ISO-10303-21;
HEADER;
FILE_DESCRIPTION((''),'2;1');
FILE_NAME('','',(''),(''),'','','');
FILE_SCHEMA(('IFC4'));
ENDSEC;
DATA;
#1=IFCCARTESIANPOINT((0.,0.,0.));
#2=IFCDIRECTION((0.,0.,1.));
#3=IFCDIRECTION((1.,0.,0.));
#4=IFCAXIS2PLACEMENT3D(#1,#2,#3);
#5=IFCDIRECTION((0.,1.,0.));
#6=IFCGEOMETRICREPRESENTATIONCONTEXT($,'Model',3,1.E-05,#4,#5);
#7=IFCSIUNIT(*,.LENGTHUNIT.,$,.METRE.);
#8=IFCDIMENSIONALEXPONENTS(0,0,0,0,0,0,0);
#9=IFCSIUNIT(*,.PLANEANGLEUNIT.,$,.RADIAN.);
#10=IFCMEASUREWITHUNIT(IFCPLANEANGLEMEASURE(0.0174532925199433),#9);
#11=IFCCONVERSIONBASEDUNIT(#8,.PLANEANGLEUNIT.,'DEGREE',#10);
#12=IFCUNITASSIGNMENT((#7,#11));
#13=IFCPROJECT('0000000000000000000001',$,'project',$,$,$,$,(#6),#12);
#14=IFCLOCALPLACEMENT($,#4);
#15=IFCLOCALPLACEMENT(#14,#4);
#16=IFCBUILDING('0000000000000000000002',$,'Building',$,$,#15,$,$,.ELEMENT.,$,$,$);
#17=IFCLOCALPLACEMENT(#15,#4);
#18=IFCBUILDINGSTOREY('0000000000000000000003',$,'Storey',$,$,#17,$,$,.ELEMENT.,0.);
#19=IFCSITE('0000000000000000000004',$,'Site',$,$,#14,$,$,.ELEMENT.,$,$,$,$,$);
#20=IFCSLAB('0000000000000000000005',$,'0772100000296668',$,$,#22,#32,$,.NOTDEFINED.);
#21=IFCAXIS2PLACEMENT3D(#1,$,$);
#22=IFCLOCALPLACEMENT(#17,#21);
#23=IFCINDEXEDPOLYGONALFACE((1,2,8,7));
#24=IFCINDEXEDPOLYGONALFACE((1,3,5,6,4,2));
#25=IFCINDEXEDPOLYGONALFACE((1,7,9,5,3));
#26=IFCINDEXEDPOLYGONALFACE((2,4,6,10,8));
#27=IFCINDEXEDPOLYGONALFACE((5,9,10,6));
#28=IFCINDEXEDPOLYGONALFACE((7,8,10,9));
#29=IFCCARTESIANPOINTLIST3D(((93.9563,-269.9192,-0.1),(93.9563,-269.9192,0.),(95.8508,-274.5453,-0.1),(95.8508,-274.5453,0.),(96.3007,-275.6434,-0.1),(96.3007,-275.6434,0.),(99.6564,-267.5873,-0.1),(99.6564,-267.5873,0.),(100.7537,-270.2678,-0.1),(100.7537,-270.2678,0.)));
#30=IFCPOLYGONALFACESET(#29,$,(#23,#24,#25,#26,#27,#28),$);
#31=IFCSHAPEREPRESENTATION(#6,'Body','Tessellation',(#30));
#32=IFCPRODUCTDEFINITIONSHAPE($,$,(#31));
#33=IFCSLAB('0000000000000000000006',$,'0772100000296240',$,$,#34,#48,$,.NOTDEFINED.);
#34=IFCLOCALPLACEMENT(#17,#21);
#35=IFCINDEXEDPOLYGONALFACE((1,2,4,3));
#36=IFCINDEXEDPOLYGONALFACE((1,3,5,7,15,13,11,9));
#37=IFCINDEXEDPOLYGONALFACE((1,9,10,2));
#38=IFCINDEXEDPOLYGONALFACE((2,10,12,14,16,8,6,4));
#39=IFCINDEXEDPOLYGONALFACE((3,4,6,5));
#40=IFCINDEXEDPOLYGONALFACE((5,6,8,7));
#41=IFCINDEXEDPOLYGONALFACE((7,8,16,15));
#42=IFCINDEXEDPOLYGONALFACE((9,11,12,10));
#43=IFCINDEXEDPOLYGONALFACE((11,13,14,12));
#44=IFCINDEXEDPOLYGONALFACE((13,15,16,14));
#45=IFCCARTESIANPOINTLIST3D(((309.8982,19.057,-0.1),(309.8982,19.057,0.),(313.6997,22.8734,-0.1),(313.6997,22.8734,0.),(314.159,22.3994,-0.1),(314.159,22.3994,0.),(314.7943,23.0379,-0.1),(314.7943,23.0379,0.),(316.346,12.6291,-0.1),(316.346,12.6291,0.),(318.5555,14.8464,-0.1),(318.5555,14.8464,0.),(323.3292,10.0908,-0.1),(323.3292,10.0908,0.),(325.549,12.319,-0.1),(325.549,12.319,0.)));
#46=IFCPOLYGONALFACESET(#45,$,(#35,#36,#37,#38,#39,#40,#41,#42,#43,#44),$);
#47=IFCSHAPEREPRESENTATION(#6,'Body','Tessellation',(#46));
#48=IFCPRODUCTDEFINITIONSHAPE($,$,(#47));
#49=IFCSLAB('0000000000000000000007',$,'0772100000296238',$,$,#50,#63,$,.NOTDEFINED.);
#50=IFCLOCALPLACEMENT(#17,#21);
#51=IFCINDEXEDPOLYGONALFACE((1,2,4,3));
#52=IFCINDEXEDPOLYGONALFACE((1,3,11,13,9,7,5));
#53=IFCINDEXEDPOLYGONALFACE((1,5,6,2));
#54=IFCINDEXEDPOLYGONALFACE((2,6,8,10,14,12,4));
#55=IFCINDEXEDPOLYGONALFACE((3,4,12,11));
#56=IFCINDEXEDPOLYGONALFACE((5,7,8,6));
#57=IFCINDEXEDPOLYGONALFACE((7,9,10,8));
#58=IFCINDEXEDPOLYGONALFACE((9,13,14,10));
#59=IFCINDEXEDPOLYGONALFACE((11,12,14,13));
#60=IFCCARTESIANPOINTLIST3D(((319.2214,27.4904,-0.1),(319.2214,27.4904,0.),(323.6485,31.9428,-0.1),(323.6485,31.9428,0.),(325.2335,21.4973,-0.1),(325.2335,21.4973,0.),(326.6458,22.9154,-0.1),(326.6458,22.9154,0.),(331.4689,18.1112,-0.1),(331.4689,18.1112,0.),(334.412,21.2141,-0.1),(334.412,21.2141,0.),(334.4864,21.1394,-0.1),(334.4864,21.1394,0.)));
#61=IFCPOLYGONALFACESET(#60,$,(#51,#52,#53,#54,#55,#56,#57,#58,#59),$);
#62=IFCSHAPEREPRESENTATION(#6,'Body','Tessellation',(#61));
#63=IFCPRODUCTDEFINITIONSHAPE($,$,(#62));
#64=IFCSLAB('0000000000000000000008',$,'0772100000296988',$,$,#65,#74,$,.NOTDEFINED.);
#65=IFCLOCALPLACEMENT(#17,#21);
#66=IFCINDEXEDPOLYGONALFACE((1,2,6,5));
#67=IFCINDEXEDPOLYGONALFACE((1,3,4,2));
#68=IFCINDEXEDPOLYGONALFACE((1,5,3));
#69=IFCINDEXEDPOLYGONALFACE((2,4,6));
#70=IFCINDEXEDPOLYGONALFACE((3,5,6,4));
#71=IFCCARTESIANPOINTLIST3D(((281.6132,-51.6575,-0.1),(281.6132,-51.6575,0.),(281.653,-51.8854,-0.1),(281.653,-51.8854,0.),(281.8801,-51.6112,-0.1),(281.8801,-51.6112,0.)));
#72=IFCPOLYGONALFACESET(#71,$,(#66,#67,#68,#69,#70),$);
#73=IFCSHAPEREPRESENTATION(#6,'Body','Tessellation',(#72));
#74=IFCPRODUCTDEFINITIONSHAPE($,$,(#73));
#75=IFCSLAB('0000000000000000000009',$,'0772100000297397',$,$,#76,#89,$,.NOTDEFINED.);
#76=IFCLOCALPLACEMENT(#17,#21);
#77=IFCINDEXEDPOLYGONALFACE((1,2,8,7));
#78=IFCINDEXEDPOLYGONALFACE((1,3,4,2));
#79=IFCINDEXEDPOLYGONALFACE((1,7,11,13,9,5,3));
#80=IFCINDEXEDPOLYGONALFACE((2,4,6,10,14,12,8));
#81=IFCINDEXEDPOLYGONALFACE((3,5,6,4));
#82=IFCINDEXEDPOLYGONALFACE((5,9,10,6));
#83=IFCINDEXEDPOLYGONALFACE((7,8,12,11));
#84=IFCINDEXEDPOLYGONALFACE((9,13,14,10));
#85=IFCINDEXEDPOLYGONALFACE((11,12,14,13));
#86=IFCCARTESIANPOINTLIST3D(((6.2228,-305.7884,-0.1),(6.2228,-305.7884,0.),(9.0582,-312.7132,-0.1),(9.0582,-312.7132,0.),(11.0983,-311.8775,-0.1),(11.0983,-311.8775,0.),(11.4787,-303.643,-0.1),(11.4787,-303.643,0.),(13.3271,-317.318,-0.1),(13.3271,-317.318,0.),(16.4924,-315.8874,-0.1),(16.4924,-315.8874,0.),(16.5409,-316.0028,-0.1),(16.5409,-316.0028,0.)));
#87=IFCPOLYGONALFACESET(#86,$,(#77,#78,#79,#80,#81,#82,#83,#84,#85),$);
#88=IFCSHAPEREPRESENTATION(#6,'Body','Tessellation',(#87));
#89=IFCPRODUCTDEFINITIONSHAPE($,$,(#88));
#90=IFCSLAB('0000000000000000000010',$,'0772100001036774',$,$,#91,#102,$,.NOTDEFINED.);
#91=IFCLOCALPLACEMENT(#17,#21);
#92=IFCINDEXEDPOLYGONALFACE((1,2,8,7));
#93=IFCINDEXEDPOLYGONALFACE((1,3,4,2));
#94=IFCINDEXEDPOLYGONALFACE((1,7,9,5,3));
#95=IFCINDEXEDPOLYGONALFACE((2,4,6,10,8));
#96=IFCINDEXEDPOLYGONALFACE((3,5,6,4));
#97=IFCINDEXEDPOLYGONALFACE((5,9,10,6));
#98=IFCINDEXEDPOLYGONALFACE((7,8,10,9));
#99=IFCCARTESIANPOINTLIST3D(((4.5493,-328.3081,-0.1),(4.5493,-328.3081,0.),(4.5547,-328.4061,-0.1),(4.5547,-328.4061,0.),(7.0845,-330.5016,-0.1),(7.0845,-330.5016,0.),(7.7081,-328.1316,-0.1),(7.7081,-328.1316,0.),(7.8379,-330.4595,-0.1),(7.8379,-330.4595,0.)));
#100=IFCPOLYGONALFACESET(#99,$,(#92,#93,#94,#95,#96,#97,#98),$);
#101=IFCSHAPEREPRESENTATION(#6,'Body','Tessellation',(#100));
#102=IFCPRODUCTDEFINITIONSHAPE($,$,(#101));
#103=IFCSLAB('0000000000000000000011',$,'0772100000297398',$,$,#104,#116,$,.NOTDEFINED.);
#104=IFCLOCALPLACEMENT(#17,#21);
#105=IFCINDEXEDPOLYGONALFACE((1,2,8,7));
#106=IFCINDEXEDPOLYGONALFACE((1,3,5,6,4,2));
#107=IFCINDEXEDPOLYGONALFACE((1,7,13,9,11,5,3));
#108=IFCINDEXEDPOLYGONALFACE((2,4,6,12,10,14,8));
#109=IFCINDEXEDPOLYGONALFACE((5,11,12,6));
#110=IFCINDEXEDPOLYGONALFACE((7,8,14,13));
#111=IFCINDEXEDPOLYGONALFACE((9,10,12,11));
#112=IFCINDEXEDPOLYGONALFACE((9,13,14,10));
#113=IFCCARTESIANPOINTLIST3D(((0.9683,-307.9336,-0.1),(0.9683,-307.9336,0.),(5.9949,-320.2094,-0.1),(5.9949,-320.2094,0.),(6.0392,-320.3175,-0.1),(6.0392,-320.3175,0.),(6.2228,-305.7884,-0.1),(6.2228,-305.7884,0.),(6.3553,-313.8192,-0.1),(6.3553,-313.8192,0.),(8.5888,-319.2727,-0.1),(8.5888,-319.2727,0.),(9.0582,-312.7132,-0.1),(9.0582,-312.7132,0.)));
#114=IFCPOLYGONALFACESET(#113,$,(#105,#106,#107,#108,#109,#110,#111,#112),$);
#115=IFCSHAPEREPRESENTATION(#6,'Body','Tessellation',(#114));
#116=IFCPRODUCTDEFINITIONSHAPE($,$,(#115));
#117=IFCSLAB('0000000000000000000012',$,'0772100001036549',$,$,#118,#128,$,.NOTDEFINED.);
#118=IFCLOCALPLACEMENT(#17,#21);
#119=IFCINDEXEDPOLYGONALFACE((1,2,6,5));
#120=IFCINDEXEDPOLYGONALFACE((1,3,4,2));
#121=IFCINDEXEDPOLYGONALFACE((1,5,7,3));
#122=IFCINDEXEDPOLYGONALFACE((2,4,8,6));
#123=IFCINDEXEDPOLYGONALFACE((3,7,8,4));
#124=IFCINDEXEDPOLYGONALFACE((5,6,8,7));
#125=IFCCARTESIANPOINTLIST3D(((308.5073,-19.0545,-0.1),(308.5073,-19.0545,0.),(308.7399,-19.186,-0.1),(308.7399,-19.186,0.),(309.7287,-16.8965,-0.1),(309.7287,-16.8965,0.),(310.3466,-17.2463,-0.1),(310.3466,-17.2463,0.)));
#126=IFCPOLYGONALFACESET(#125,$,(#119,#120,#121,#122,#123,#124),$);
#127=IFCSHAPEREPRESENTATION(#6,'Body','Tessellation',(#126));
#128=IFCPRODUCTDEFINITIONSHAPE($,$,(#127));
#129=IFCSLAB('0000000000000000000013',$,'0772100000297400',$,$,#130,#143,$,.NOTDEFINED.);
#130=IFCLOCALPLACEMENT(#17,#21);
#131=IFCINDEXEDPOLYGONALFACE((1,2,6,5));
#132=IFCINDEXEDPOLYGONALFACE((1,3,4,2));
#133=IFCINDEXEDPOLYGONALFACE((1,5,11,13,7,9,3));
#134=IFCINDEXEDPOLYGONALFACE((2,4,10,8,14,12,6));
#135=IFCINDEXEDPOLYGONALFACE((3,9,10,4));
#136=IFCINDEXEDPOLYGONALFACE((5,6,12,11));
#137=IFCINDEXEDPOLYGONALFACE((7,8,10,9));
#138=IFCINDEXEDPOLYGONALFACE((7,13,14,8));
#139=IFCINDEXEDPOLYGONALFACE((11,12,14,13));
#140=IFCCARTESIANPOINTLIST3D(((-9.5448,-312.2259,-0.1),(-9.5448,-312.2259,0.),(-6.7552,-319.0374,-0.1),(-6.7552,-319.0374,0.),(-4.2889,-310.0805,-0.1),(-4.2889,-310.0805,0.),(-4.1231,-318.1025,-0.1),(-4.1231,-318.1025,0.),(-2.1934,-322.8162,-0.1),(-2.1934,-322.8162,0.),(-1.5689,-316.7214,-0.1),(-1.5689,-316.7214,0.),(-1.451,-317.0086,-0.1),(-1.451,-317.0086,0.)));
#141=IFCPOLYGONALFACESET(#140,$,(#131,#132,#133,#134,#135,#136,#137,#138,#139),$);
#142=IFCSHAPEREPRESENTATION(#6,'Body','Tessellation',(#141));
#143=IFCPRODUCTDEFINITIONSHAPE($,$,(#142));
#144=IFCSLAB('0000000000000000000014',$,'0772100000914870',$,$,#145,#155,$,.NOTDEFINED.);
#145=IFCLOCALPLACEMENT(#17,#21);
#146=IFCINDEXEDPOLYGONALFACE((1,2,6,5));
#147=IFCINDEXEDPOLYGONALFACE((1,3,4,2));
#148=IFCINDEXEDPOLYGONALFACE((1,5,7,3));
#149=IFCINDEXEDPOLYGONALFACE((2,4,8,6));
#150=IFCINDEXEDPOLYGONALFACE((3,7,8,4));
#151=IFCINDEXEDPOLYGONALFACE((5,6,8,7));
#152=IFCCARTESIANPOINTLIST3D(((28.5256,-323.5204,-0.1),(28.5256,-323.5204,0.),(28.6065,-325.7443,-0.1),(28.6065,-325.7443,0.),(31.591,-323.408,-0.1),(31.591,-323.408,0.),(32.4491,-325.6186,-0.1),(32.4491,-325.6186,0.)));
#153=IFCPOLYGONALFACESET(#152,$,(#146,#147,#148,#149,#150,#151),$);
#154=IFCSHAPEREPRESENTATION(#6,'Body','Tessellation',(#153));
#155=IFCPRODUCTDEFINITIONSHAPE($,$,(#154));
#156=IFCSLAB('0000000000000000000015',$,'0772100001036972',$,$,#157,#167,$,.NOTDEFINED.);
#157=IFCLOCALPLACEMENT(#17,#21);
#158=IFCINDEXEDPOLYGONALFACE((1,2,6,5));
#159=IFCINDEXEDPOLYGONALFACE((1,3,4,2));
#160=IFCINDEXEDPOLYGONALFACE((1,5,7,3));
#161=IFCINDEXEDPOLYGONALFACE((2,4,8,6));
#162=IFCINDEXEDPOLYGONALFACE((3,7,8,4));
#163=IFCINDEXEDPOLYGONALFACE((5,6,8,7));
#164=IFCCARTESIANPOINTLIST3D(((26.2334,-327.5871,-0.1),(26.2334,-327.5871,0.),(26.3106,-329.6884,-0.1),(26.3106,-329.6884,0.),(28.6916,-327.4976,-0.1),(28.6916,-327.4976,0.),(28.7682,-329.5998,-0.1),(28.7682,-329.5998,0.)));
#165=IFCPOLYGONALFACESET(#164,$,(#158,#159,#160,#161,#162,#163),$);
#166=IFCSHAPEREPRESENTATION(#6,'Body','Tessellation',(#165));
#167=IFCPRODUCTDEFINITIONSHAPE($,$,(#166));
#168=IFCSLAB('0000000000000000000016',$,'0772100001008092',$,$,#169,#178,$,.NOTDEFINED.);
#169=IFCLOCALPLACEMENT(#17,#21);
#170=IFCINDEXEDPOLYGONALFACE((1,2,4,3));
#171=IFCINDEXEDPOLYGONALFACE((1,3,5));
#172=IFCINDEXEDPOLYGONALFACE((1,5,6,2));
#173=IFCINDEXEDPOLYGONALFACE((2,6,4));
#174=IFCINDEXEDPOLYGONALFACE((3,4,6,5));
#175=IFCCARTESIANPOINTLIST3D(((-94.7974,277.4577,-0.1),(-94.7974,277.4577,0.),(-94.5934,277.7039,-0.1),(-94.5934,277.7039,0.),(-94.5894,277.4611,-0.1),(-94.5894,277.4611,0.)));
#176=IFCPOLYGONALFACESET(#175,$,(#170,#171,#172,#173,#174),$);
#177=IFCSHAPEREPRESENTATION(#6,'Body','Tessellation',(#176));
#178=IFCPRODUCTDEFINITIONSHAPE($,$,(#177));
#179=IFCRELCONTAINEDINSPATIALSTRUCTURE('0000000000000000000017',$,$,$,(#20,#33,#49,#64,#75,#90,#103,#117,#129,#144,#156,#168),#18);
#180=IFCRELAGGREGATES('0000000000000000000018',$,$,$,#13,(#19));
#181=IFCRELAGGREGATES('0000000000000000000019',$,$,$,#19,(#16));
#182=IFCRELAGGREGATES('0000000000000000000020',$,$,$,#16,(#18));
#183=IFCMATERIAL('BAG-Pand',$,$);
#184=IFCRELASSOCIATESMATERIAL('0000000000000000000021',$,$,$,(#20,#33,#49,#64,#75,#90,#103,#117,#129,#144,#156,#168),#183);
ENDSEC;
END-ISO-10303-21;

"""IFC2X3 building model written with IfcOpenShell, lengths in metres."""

from ifc_helpers import new_model, entity, si_unit, converted_unit, direction, frame, origin_with_axes, place, context, project, spatial, polyline, outline, extrude, material, element, save


model = new_model("IFC2X3")

# Units and contexts
model_context = context("Model", 3, precision=1e-05, world=origin_with_axes(), true_north=direction((0.0, 1.0, 0.0)))
ifc_project = project(units=[si_unit("LENGTHUNIT", "METRE"), converted_unit("PLANEANGLEUNIT", "DEGREE", entity("IfcPlaneAngleMeasure", 0.0174532925199433), si_unit("PLANEANGLEUNIT", "RADIAN"), dimensions=[0, 0, 0, 0, 0, 0, 0])], contexts=[model_context])

# Site, building, storey
site_placement = place(None, origin_with_axes())
site = spatial("IfcSite", under=ifc_project, at=site_placement, Name="Site", CompositionType="ELEMENT")
building_placement = place(site_placement, origin_with_axes())
building = spatial("IfcBuilding", under=site, at=building_placement, Name="Building", CompositionType="ELEMENT")
storey_placement = place(building_placement, origin_with_axes())
storey = spatial("IfcBuildingStorey", under=building, at=storey_placement, Name="Storey", CompositionType="ELEMENT", Elevation=0.0)

# Slabs
ifc_material = material(Name="BAG-Pand")
slab_1_placement = place(storey_placement, frame((0.0, 0.0, -0.1), z_axis=(0.0, 0.0, 1.0), x_axis=(1.0, 0.0, 0.0)))
element("IfcSlab", 1, at=slab_1_placement, inside=storey, material=ifc_material, Name="0772100000296668", PredefinedType="NOTDEFINED", context=model_context, shape_type="SweptSolid", body=[
    extrude(outline(polyline([(95.8508, -274.5453), (93.9563, -269.9192), (99.6564, -267.5873), (100.7537, -270.2678), (96.3007, -275.6434), (95.8508, -274.5453)])), origin_with_axes(), (0.0, 0.0, 1.0), 0.1),
])
slab_2_placement = place(storey_placement, frame((0.0, 0.0, -0.1), z_axis=(0.0, 0.0, 1.0), x_axis=(1.0, 0.0, 0.0)))
element("IfcSlab", 2, at=slab_2_placement, inside=storey, material=ifc_material, Name="0772100000296240", PredefinedType="NOTDEFINED", context=model_context, shape_type="SweptSolid", body=[
    extrude(outline(polyline([(309.8982, 19.057), (313.6997, 22.8734), (314.159, 22.3994), (314.7943, 23.0379), (325.549, 12.319), (323.3292, 10.0908), (318.5555, 14.8464), (316.346, 12.6291), (309.8982, 19.057)])), origin_with_axes(), (0.0, 0.0, 1.0), 0.1),
])
slab_3_placement = place(storey_placement, frame((0.0, 0.0, -0.1), z_axis=(0.0, 0.0, 1.0), x_axis=(1.0, 0.0, 0.0)))
element("IfcSlab", 3, at=slab_3_placement, inside=storey, material=ifc_material, Name="0772100000296238", PredefinedType="NOTDEFINED", context=model_context, shape_type="SweptSolid", body=[
    extrude(outline(polyline([(319.2214, 27.4904), (323.6485, 31.9428), (334.412, 21.2141), (334.4864, 21.1394), (331.4689, 18.1112), (326.6458, 22.9154), (325.2335, 21.4973), (319.2214, 27.4904)])), origin_with_axes(), (0.0, 0.0, 1.0), 0.1),
])
slab_4_placement = place(storey_placement, frame((0.0, 0.0, -0.1), z_axis=(0.0, 0.0, 1.0), x_axis=(1.0, 0.0, 0.0)))
element("IfcSlab", 4, at=slab_4_placement, inside=storey, material=ifc_material, Name="0772100000296988", PredefinedType="NOTDEFINED", context=model_context, shape_type="SweptSolid", body=[
    extrude(outline(polyline([(281.6132, -51.6575), (281.8801, -51.6112), (281.653, -51.8854), (281.6132, -51.6575)])), origin_with_axes(), (0.0, 0.0, 1.0), 0.1),
])
slab_5_placement = place(storey_placement, frame((0.0, 0.0, -0.1), z_axis=(0.0, 0.0, 1.0), x_axis=(1.0, 0.0, 0.0)))
element("IfcSlab", 5, at=slab_5_placement, inside=storey, material=ifc_material, Name="0772100000297397", PredefinedType="NOTDEFINED", context=model_context, shape_type="SweptSolid", body=[
    extrude(outline(polyline([(11.4787, -303.643), (16.4924, -315.8874), (16.5409, -316.0028), (13.3271, -317.318), (11.0983, -311.8775), (9.0582, -312.7132), (6.2228, -305.7884), (11.4787, -303.643)])), origin_with_axes(), (0.0, 0.0, 1.0), 0.1),
])
slab_6_placement = place(storey_placement, frame((0.0, 0.0, -0.1), z_axis=(0.0, 0.0, 1.0), x_axis=(1.0, 0.0, 0.0)))
element("IfcSlab", 6, at=slab_6_placement, inside=storey, material=ifc_material, Name="0772100001036774", PredefinedType="NOTDEFINED", context=model_context, shape_type="SweptSolid", body=[
    extrude(outline(polyline([(4.5493, -328.3081), (7.7081, -328.1316), (7.8379, -330.4595), (7.0845, -330.5016), (4.5547, -328.4061), (4.5493, -328.3081)])), origin_with_axes(), (0.0, 0.0, 1.0), 0.1),
])
slab_7_placement = place(storey_placement, frame((0.0, 0.0, -0.1), z_axis=(0.0, 0.0, 1.0), x_axis=(1.0, 0.0, 0.0)))
element("IfcSlab", 7, at=slab_7_placement, inside=storey, material=ifc_material, Name="0772100000297398", PredefinedType="NOTDEFINED", context=model_context, shape_type="SweptSolid", body=[
    extrude(outline(polyline([(5.9949, -320.2094), (0.9683, -307.9336), (6.2228, -305.7884), (9.0582, -312.7132), (6.3553, -313.8192), (8.5888, -319.2727), (6.0392, -320.3175), (5.9949, -320.2094)])), origin_with_axes(), (0.0, 0.0, 1.0), 0.1),
])
slab_8_placement = place(storey_placement, frame((0.0, 0.0, -0.1), z_axis=(0.0, 0.0, 1.0), x_axis=(1.0, 0.0, 0.0)))
element("IfcSlab", 8, at=slab_8_placement, inside=storey, material=ifc_material, Name="0772100001036549", PredefinedType="NOTDEFINED", context=model_context, shape_type="SweptSolid", body=[
    extrude(outline(polyline([(308.5073, -19.0545), (309.7287, -16.8965), (310.3466, -17.2463), (308.7399, -19.186), (308.5073, -19.0545)])), origin_with_axes(), (0.0, 0.0, 1.0), 0.1),
])
slab_9_placement = place(storey_placement, frame((0.0, 0.0, -0.1), z_axis=(0.0, 0.0, 1.0), x_axis=(1.0, 0.0, 0.0)))
element("IfcSlab", 9, at=slab_9_placement, inside=storey, material=ifc_material, Name="0772100000297400", PredefinedType="NOTDEFINED", context=model_context, shape_type="SweptSolid", body=[
    extrude(outline(polyline([(-9.5448, -312.2259), (-4.2889, -310.0805), (-1.5689, -316.7214), (-1.451, -317.0086), (-4.1231, -318.1025), (-2.1934, -322.8162), (-6.7552, -319.0374), (-9.5448, -312.2259)])), origin_with_axes(), (0.0, 0.0, 1.0), 0.1),
])
slab_10_placement = place(storey_placement, frame((0.0, 0.0, -0.1), z_axis=(0.0, 0.0, 1.0), x_axis=(1.0, 0.0, 0.0)))
element("IfcSlab", 10, at=slab_10_placement, inside=storey, material=ifc_material, Name="0772100000914870", PredefinedType="NOTDEFINED", context=model_context, shape_type="SweptSolid", body=[
    extrude(outline(polyline([(28.5256, -323.5204), (31.591, -323.408), (32.4491, -325.6186), (28.6065, -325.7443), (28.5256, -323.5204)])), origin_with_axes(), (0.0, 0.0, 1.0), 0.1),
])
slab_11_placement = place(storey_placement, frame((0.0, 0.0, -0.1), z_axis=(0.0, 0.0, 1.0), x_axis=(1.0, 0.0, 0.0)))
element("IfcSlab", 11, at=slab_11_placement, inside=storey, material=ifc_material, Name="0772100001036972", PredefinedType="NOTDEFINED", context=model_context, shape_type="SweptSolid", body=[
    extrude(outline(polyline([(26.2334, -327.5871), (28.6916, -327.4976), (28.7682, -329.5998), (26.3106, -329.6884), (26.2334, -327.5871)])), origin_with_axes(), (0.0, 0.0, 1.0), 0.1),
])
slab_12_placement = place(storey_placement, frame((0.0, 0.0, -0.1), z_axis=(0.0, 0.0, 1.0), x_axis=(1.0, 0.0, 0.0)))
element("IfcSlab", 12, at=slab_12_placement, inside=storey, material=ifc_material, Name="0772100001008092", PredefinedType="NOTDEFINED", context=model_context, shape_type="SweptSolid", body=[
    extrude(outline(polyline([(-94.5894, 277.4611), (-94.7974, 277.4577), (-94.5934, 277.7039), (-94.5894, 277.4611)])), origin_with_axes(), (0.0, 0.0, 1.0), 0.1),
])

save(model, "model.ifc")
